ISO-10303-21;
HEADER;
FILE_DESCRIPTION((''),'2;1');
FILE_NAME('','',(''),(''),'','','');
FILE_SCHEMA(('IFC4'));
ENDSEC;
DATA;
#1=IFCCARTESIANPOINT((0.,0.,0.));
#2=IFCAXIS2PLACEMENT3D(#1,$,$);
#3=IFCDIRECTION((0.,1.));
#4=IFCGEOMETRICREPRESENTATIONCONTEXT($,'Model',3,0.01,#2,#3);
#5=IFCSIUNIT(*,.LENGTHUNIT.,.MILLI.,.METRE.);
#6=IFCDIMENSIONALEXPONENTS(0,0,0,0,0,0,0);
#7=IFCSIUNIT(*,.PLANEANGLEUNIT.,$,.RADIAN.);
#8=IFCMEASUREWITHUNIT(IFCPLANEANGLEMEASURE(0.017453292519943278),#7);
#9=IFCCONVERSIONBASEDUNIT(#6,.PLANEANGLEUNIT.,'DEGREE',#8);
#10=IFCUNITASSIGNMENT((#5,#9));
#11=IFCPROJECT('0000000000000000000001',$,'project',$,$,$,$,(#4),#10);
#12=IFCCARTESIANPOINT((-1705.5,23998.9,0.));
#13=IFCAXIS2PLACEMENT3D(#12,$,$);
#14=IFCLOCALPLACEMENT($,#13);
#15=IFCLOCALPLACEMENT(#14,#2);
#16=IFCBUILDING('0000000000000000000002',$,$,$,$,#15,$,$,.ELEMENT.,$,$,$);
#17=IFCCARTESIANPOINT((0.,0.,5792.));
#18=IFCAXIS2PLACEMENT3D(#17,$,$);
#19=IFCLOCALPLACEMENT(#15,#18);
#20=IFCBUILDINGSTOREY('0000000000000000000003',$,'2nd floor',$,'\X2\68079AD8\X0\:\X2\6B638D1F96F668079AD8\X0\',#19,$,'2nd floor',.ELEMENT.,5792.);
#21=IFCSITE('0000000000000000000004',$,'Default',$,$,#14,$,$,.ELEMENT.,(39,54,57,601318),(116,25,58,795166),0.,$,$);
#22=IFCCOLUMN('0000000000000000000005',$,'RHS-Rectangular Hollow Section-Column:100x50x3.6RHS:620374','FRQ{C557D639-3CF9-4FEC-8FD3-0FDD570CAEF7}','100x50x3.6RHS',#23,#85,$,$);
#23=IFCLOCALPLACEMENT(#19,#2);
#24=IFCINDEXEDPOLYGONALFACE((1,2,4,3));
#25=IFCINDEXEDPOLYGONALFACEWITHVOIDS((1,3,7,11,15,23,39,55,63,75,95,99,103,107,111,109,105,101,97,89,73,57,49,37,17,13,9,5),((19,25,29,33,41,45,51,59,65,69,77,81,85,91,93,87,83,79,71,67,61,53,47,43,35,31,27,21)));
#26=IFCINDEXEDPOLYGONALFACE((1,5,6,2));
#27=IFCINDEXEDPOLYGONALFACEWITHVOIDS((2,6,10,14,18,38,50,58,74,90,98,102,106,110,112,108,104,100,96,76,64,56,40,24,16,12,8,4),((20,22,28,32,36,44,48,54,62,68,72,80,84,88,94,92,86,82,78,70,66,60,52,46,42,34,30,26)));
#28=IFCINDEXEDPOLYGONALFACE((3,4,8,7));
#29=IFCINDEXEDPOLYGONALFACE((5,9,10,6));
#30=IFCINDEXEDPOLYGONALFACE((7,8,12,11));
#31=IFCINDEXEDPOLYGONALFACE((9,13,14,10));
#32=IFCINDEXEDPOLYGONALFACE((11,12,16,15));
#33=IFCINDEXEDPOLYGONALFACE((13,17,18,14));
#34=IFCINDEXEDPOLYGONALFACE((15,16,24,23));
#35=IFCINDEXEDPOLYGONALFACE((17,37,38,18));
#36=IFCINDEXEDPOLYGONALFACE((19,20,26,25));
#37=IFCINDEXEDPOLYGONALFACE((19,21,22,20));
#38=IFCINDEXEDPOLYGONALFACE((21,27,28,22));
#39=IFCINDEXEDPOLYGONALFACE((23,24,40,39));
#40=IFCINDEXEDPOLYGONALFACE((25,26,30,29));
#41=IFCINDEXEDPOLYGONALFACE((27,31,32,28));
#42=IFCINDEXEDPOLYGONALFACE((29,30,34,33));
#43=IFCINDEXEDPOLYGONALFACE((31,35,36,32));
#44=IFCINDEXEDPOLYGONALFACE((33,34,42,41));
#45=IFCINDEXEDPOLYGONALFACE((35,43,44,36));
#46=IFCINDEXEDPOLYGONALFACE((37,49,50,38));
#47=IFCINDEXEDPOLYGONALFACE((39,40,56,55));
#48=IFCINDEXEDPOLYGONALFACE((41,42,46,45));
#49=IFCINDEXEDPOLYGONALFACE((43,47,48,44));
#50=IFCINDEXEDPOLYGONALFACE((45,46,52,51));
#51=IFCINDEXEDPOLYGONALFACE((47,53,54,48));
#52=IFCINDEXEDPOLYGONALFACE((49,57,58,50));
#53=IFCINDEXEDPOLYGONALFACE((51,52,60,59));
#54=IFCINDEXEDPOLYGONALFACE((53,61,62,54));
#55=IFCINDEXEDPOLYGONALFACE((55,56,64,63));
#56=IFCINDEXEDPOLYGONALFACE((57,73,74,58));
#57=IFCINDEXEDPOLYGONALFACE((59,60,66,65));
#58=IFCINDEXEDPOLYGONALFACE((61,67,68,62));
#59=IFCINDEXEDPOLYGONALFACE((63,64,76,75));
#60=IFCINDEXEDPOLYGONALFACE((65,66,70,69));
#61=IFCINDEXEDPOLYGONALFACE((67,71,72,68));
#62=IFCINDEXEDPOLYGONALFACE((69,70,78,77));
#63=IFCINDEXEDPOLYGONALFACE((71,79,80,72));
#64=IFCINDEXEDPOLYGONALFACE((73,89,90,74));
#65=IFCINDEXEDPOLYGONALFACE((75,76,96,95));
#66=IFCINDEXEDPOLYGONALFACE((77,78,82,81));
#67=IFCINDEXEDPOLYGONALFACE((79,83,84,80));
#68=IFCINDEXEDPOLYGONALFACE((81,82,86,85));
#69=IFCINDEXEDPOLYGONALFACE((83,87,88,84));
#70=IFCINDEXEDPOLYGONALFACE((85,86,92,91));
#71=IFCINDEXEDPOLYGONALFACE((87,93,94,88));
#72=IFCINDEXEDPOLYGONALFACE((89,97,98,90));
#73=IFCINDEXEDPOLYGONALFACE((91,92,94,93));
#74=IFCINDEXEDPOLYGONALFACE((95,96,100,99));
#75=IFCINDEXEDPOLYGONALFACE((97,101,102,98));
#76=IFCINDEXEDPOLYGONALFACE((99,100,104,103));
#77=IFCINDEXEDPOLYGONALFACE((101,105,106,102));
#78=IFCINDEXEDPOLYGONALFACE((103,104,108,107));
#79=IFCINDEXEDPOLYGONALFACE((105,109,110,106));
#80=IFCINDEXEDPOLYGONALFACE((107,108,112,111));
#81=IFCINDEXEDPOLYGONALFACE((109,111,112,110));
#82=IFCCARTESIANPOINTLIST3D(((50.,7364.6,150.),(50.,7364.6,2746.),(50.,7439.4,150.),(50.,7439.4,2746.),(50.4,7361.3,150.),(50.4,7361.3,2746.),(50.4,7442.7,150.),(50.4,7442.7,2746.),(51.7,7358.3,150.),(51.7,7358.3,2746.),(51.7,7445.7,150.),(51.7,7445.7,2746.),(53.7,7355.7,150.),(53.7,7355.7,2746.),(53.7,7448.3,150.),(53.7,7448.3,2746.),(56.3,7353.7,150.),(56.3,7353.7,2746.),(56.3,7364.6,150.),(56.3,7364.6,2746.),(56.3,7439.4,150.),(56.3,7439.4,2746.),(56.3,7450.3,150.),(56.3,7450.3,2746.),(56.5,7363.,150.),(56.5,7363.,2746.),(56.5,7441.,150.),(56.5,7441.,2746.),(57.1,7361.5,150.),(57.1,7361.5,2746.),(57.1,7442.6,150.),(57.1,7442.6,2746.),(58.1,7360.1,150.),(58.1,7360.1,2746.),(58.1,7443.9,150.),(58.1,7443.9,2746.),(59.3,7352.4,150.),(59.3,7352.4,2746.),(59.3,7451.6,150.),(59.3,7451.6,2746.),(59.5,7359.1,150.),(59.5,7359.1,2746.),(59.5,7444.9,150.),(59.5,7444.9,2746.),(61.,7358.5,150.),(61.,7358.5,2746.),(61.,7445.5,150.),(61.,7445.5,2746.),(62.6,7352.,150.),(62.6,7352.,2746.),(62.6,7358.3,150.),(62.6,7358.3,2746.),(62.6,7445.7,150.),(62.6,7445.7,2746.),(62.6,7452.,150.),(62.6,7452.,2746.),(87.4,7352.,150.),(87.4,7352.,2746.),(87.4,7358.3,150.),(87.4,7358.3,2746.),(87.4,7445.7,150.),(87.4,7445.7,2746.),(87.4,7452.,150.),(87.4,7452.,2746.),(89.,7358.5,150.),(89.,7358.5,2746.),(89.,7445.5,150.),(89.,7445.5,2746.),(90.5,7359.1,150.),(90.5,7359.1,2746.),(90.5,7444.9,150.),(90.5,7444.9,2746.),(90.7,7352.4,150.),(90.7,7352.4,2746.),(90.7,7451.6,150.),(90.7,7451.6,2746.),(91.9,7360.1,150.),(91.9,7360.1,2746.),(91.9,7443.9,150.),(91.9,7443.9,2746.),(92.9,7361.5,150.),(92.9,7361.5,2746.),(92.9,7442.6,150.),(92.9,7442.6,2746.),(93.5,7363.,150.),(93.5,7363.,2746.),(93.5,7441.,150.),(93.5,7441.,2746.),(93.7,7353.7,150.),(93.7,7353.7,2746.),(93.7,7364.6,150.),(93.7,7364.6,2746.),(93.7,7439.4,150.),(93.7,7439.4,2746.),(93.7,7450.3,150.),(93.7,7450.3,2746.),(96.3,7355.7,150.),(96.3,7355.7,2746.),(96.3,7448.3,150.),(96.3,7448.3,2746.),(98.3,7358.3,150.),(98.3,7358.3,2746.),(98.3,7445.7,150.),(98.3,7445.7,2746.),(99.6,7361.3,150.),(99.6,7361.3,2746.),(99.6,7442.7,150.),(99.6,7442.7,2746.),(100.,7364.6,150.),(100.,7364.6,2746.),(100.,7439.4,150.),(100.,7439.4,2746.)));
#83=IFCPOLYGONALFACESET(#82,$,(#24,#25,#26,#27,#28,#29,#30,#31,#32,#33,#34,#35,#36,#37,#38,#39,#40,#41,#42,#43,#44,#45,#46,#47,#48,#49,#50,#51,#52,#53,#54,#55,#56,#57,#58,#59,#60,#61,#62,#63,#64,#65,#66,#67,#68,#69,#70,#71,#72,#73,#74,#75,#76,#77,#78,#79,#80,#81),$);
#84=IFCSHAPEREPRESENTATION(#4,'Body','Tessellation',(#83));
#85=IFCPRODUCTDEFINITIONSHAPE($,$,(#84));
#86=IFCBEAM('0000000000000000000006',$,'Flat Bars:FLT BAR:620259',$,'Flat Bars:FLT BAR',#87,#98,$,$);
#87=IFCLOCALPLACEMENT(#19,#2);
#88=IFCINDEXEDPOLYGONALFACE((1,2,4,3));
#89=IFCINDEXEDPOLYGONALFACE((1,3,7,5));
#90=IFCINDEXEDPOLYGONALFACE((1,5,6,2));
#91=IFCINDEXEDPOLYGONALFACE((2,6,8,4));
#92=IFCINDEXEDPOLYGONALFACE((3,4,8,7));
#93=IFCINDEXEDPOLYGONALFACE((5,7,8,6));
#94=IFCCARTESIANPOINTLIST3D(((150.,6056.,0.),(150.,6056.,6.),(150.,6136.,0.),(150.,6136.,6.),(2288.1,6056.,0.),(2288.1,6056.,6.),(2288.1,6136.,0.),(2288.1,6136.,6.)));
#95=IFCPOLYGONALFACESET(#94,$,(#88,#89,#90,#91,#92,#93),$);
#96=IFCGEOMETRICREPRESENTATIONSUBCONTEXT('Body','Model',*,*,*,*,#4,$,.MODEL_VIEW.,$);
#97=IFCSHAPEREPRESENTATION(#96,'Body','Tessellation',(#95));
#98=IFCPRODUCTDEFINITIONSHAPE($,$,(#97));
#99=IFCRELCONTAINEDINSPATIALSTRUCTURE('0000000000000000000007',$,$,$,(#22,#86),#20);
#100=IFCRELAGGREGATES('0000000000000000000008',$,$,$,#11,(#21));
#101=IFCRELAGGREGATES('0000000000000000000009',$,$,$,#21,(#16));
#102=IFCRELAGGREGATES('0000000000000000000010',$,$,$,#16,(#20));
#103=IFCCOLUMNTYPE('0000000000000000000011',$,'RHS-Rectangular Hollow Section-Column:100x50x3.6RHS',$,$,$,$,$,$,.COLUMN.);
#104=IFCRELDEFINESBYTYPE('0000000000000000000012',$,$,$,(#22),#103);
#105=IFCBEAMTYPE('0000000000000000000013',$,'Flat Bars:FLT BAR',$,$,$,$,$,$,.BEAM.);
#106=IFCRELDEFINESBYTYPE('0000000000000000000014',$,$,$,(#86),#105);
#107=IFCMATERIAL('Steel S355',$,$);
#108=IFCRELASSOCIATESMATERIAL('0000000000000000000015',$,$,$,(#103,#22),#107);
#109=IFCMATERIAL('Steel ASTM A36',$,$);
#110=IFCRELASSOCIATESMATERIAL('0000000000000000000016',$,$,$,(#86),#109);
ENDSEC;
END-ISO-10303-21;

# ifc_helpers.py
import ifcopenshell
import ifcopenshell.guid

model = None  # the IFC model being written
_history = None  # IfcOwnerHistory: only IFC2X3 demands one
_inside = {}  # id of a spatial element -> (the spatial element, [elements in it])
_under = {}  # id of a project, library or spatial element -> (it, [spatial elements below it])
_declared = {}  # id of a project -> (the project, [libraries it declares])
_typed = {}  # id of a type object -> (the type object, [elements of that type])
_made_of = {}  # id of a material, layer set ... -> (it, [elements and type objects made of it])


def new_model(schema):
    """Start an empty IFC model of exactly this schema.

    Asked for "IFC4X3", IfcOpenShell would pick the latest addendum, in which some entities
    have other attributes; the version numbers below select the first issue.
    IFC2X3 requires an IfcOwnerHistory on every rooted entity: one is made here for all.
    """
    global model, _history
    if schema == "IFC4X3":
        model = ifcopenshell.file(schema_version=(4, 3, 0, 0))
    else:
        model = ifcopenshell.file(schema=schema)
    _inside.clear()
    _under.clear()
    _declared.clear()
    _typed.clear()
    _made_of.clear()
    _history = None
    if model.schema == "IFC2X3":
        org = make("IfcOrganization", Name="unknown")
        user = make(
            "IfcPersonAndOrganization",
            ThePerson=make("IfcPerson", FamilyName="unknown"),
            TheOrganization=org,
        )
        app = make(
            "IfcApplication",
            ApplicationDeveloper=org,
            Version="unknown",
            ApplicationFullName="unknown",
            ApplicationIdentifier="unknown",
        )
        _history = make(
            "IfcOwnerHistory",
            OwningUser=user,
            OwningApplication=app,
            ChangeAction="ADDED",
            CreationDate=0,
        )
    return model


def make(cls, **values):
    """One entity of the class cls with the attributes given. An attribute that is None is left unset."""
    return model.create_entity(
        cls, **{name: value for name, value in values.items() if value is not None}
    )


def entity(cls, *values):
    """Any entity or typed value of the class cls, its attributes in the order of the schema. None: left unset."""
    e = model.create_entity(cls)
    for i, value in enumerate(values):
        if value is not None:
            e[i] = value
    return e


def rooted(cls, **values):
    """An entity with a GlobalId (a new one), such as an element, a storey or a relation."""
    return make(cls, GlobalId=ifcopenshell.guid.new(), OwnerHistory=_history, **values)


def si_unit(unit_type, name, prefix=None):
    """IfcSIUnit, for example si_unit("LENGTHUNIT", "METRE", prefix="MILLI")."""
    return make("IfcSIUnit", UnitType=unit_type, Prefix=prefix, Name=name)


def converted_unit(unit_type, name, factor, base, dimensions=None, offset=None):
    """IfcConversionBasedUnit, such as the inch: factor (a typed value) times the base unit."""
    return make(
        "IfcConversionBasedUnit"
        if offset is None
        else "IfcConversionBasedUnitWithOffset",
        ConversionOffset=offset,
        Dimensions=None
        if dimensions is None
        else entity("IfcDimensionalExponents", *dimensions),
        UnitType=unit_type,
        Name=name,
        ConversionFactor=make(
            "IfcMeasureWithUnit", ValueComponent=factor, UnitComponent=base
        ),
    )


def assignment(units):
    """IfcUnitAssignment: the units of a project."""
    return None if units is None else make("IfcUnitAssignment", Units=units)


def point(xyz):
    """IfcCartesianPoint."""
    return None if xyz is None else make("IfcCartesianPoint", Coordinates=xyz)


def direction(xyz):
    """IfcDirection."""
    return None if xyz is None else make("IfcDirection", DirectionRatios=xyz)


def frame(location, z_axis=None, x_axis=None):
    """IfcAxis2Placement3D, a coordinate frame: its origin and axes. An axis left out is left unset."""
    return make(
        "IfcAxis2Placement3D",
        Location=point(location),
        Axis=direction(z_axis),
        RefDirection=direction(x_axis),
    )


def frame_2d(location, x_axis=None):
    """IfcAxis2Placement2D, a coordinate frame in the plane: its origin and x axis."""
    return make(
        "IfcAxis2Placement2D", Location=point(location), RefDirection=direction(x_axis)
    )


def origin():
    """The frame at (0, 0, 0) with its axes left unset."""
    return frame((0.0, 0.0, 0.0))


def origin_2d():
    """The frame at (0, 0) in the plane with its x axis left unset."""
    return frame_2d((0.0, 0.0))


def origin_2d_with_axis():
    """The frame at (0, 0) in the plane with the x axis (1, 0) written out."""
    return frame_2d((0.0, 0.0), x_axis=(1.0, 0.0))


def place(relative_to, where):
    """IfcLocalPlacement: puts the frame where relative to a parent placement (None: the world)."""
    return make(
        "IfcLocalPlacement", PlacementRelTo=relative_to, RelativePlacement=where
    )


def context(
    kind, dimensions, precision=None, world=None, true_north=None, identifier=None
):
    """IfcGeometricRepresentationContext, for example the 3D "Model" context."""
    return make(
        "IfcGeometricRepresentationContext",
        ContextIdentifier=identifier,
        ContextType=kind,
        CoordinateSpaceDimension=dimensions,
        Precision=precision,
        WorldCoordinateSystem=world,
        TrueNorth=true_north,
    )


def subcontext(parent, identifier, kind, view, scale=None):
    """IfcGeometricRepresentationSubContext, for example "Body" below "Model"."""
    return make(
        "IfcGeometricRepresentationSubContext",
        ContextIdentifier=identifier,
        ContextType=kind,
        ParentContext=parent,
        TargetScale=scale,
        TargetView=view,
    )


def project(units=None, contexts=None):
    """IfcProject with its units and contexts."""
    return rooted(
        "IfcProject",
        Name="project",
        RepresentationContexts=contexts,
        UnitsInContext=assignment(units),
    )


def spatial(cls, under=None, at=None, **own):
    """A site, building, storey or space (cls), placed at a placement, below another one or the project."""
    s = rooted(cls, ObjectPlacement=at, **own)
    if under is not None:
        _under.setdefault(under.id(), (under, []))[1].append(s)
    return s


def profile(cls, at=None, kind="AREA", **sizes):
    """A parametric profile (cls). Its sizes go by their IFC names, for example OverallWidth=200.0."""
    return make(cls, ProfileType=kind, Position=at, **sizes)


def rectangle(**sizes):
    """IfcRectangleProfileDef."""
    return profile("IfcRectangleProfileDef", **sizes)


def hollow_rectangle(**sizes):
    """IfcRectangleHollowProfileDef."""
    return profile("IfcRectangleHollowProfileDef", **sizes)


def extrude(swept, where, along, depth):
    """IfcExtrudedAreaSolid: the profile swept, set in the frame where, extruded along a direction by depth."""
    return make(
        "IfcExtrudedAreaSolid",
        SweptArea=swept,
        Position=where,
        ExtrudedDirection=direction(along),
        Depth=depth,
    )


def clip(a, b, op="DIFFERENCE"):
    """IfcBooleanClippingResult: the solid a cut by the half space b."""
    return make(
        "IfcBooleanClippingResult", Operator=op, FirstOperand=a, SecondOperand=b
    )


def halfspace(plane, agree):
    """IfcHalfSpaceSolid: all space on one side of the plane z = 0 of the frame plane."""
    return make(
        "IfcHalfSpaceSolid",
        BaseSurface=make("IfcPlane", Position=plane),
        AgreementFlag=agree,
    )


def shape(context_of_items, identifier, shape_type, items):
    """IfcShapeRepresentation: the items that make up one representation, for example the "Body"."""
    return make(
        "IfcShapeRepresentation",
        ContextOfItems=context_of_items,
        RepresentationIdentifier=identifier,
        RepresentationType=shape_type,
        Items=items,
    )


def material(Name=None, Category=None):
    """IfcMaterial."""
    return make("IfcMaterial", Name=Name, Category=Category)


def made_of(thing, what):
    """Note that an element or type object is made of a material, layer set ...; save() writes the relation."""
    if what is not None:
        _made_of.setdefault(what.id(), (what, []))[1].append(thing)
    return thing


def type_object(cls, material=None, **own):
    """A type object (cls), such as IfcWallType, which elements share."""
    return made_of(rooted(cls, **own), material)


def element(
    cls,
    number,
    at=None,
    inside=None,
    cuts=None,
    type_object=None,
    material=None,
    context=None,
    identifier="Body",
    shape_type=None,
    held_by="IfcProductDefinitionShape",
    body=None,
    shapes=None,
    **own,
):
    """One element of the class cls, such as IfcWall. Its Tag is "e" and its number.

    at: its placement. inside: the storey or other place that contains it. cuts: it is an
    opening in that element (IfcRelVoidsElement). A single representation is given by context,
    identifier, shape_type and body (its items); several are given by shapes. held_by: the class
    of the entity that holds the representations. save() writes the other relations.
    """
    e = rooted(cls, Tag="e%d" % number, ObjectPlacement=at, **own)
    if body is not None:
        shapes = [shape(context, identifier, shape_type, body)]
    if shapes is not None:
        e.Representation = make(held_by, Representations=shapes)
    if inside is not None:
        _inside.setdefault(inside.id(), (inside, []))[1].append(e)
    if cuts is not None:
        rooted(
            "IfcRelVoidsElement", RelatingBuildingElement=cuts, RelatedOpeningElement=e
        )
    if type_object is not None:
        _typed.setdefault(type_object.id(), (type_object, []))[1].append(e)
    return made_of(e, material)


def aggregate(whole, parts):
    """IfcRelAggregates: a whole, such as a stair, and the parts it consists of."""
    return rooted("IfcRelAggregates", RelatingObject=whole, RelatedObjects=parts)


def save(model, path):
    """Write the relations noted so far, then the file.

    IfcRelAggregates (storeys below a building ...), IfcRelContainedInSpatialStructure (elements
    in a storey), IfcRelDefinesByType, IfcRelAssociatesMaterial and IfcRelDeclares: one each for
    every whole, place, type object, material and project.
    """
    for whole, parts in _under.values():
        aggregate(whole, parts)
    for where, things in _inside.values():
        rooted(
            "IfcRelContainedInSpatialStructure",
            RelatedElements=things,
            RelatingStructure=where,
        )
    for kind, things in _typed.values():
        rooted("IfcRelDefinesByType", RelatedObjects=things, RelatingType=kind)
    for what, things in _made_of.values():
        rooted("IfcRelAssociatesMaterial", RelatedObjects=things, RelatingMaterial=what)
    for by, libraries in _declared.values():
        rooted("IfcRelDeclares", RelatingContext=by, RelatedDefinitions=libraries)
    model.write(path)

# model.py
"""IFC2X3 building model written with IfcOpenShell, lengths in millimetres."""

from ifc_helpers import new_model, entity, si_unit, converted_unit, direction, frame, origin, origin_2d, origin_2d_with_axis, place, context, subcontext, project, spatial, rectangle, hollow_rectangle, extrude, clip, halfspace, material, type_object, element, save


model = new_model("IFC2X3")

# Units and contexts
model_context = context("Model", 3, precision=0.01, world=origin(), true_north=direction((0.0, 1.0)))
body_context = subcontext(model_context, "Body", "Model", "MODEL_VIEW")
ifc_project = project(units=[si_unit("LENGTHUNIT", "METRE", prefix="MILLI"), converted_unit("PLANEANGLEUNIT", "DEGREE", entity("IfcPlaneAngleMeasure", 0.017453292519943278), si_unit("PLANEANGLEUNIT", "RADIAN"), dimensions=[0, 0, 0, 0, 0, 0, 0])], contexts=[model_context])

# Site, building, storey
site_placement = place(None, frame((-1705.5, 23998.9, 0.0)))
site = spatial("IfcSite", under=ifc_project, at=site_placement, Name="Default", CompositionType="ELEMENT", RefLatitude=(39, 54, 57, 601318), RefLongitude=(116, 25, 58, 795166), RefElevation=0.0)
building_placement = place(site_placement, origin())
building = spatial("IfcBuilding", under=site, at=building_placement, CompositionType="ELEMENT")
storey_placement = place(building_placement, frame((0.0, 0.0, 5792.0)))
storey = spatial("IfcBuildingStorey", under=building, at=storey_placement, Name="2nd floor", ObjectType="标高:正负零标高", LongName="2nd floor", CompositionType="ELEMENT", Elevation=5792.0)

# Column
ifc_material_1 = material(Name="Steel S355")
column_type = type_object("IfcColumnType", Name="RHS-Rectangular Hollow Section-Column:100x50x3.6RHS", PredefinedType="COLUMN", material=ifc_material_1)
column_1_placement = place(storey_placement, frame((75.0, 7402.0, 2746.0), z_axis=(0.0, 0.0, 1.0), x_axis=(-1.0, 0.0, 0.0)))
element("IfcColumn", 1, at=column_1_placement, inside=storey, type_object=column_type, material=ifc_material_1, Name="RHS-Rectangular Hollow Section-Column:100x50x3.6RHS:620374", Description="FRQ{C557D639-3CF9-4FEC-8FD3-0FDD570CAEF7}", ObjectType="100x50x3.6RHS", context=model_context, shape_type="Clipping", body=[
    clip(extrude(hollow_rectangle(XDim=50.0, YDim=100.0, WallThickness=6.3, InnerFilletRadius=6.3, OuterFilletRadius=12.6, at=origin_2d()), origin(), (0.0, 0.0, -1.0), 2651.9), halfspace(frame((75.0, 7402.0, -2596.0), z_axis=(0.0, 0.0, 1.0), x_axis=(-1.0, 0.0, 0.0)), True)),
])

# Beam
ifc_material_2 = material(Name="Steel ASTM A36")
beam_type = type_object("IfcBeamType", Name="Flat Bars:FLT BAR", PredefinedType="BEAM")
beam_placement = place(storey_placement, frame((150.0, 6096.0, 6.0)))
element("IfcBeam", 2, at=beam_placement, inside=storey, type_object=beam_type, material=ifc_material_2, Name="Flat Bars:FLT BAR:620259", ObjectType="Flat Bars:FLT BAR", context=body_context, shape_type="SweptSolid", body=[
    extrude(rectangle(XDim=6.0, YDim=80.0, at=origin_2d_with_axis()), frame((0.0, 0.0, -3.0), z_axis=(1.0, 0.0, 0.0), x_axis=(0.0, 0.0, -1.0)), (0.0, 0.0, 1.0), 2138.1),
])

save(model, "model.ifc")
